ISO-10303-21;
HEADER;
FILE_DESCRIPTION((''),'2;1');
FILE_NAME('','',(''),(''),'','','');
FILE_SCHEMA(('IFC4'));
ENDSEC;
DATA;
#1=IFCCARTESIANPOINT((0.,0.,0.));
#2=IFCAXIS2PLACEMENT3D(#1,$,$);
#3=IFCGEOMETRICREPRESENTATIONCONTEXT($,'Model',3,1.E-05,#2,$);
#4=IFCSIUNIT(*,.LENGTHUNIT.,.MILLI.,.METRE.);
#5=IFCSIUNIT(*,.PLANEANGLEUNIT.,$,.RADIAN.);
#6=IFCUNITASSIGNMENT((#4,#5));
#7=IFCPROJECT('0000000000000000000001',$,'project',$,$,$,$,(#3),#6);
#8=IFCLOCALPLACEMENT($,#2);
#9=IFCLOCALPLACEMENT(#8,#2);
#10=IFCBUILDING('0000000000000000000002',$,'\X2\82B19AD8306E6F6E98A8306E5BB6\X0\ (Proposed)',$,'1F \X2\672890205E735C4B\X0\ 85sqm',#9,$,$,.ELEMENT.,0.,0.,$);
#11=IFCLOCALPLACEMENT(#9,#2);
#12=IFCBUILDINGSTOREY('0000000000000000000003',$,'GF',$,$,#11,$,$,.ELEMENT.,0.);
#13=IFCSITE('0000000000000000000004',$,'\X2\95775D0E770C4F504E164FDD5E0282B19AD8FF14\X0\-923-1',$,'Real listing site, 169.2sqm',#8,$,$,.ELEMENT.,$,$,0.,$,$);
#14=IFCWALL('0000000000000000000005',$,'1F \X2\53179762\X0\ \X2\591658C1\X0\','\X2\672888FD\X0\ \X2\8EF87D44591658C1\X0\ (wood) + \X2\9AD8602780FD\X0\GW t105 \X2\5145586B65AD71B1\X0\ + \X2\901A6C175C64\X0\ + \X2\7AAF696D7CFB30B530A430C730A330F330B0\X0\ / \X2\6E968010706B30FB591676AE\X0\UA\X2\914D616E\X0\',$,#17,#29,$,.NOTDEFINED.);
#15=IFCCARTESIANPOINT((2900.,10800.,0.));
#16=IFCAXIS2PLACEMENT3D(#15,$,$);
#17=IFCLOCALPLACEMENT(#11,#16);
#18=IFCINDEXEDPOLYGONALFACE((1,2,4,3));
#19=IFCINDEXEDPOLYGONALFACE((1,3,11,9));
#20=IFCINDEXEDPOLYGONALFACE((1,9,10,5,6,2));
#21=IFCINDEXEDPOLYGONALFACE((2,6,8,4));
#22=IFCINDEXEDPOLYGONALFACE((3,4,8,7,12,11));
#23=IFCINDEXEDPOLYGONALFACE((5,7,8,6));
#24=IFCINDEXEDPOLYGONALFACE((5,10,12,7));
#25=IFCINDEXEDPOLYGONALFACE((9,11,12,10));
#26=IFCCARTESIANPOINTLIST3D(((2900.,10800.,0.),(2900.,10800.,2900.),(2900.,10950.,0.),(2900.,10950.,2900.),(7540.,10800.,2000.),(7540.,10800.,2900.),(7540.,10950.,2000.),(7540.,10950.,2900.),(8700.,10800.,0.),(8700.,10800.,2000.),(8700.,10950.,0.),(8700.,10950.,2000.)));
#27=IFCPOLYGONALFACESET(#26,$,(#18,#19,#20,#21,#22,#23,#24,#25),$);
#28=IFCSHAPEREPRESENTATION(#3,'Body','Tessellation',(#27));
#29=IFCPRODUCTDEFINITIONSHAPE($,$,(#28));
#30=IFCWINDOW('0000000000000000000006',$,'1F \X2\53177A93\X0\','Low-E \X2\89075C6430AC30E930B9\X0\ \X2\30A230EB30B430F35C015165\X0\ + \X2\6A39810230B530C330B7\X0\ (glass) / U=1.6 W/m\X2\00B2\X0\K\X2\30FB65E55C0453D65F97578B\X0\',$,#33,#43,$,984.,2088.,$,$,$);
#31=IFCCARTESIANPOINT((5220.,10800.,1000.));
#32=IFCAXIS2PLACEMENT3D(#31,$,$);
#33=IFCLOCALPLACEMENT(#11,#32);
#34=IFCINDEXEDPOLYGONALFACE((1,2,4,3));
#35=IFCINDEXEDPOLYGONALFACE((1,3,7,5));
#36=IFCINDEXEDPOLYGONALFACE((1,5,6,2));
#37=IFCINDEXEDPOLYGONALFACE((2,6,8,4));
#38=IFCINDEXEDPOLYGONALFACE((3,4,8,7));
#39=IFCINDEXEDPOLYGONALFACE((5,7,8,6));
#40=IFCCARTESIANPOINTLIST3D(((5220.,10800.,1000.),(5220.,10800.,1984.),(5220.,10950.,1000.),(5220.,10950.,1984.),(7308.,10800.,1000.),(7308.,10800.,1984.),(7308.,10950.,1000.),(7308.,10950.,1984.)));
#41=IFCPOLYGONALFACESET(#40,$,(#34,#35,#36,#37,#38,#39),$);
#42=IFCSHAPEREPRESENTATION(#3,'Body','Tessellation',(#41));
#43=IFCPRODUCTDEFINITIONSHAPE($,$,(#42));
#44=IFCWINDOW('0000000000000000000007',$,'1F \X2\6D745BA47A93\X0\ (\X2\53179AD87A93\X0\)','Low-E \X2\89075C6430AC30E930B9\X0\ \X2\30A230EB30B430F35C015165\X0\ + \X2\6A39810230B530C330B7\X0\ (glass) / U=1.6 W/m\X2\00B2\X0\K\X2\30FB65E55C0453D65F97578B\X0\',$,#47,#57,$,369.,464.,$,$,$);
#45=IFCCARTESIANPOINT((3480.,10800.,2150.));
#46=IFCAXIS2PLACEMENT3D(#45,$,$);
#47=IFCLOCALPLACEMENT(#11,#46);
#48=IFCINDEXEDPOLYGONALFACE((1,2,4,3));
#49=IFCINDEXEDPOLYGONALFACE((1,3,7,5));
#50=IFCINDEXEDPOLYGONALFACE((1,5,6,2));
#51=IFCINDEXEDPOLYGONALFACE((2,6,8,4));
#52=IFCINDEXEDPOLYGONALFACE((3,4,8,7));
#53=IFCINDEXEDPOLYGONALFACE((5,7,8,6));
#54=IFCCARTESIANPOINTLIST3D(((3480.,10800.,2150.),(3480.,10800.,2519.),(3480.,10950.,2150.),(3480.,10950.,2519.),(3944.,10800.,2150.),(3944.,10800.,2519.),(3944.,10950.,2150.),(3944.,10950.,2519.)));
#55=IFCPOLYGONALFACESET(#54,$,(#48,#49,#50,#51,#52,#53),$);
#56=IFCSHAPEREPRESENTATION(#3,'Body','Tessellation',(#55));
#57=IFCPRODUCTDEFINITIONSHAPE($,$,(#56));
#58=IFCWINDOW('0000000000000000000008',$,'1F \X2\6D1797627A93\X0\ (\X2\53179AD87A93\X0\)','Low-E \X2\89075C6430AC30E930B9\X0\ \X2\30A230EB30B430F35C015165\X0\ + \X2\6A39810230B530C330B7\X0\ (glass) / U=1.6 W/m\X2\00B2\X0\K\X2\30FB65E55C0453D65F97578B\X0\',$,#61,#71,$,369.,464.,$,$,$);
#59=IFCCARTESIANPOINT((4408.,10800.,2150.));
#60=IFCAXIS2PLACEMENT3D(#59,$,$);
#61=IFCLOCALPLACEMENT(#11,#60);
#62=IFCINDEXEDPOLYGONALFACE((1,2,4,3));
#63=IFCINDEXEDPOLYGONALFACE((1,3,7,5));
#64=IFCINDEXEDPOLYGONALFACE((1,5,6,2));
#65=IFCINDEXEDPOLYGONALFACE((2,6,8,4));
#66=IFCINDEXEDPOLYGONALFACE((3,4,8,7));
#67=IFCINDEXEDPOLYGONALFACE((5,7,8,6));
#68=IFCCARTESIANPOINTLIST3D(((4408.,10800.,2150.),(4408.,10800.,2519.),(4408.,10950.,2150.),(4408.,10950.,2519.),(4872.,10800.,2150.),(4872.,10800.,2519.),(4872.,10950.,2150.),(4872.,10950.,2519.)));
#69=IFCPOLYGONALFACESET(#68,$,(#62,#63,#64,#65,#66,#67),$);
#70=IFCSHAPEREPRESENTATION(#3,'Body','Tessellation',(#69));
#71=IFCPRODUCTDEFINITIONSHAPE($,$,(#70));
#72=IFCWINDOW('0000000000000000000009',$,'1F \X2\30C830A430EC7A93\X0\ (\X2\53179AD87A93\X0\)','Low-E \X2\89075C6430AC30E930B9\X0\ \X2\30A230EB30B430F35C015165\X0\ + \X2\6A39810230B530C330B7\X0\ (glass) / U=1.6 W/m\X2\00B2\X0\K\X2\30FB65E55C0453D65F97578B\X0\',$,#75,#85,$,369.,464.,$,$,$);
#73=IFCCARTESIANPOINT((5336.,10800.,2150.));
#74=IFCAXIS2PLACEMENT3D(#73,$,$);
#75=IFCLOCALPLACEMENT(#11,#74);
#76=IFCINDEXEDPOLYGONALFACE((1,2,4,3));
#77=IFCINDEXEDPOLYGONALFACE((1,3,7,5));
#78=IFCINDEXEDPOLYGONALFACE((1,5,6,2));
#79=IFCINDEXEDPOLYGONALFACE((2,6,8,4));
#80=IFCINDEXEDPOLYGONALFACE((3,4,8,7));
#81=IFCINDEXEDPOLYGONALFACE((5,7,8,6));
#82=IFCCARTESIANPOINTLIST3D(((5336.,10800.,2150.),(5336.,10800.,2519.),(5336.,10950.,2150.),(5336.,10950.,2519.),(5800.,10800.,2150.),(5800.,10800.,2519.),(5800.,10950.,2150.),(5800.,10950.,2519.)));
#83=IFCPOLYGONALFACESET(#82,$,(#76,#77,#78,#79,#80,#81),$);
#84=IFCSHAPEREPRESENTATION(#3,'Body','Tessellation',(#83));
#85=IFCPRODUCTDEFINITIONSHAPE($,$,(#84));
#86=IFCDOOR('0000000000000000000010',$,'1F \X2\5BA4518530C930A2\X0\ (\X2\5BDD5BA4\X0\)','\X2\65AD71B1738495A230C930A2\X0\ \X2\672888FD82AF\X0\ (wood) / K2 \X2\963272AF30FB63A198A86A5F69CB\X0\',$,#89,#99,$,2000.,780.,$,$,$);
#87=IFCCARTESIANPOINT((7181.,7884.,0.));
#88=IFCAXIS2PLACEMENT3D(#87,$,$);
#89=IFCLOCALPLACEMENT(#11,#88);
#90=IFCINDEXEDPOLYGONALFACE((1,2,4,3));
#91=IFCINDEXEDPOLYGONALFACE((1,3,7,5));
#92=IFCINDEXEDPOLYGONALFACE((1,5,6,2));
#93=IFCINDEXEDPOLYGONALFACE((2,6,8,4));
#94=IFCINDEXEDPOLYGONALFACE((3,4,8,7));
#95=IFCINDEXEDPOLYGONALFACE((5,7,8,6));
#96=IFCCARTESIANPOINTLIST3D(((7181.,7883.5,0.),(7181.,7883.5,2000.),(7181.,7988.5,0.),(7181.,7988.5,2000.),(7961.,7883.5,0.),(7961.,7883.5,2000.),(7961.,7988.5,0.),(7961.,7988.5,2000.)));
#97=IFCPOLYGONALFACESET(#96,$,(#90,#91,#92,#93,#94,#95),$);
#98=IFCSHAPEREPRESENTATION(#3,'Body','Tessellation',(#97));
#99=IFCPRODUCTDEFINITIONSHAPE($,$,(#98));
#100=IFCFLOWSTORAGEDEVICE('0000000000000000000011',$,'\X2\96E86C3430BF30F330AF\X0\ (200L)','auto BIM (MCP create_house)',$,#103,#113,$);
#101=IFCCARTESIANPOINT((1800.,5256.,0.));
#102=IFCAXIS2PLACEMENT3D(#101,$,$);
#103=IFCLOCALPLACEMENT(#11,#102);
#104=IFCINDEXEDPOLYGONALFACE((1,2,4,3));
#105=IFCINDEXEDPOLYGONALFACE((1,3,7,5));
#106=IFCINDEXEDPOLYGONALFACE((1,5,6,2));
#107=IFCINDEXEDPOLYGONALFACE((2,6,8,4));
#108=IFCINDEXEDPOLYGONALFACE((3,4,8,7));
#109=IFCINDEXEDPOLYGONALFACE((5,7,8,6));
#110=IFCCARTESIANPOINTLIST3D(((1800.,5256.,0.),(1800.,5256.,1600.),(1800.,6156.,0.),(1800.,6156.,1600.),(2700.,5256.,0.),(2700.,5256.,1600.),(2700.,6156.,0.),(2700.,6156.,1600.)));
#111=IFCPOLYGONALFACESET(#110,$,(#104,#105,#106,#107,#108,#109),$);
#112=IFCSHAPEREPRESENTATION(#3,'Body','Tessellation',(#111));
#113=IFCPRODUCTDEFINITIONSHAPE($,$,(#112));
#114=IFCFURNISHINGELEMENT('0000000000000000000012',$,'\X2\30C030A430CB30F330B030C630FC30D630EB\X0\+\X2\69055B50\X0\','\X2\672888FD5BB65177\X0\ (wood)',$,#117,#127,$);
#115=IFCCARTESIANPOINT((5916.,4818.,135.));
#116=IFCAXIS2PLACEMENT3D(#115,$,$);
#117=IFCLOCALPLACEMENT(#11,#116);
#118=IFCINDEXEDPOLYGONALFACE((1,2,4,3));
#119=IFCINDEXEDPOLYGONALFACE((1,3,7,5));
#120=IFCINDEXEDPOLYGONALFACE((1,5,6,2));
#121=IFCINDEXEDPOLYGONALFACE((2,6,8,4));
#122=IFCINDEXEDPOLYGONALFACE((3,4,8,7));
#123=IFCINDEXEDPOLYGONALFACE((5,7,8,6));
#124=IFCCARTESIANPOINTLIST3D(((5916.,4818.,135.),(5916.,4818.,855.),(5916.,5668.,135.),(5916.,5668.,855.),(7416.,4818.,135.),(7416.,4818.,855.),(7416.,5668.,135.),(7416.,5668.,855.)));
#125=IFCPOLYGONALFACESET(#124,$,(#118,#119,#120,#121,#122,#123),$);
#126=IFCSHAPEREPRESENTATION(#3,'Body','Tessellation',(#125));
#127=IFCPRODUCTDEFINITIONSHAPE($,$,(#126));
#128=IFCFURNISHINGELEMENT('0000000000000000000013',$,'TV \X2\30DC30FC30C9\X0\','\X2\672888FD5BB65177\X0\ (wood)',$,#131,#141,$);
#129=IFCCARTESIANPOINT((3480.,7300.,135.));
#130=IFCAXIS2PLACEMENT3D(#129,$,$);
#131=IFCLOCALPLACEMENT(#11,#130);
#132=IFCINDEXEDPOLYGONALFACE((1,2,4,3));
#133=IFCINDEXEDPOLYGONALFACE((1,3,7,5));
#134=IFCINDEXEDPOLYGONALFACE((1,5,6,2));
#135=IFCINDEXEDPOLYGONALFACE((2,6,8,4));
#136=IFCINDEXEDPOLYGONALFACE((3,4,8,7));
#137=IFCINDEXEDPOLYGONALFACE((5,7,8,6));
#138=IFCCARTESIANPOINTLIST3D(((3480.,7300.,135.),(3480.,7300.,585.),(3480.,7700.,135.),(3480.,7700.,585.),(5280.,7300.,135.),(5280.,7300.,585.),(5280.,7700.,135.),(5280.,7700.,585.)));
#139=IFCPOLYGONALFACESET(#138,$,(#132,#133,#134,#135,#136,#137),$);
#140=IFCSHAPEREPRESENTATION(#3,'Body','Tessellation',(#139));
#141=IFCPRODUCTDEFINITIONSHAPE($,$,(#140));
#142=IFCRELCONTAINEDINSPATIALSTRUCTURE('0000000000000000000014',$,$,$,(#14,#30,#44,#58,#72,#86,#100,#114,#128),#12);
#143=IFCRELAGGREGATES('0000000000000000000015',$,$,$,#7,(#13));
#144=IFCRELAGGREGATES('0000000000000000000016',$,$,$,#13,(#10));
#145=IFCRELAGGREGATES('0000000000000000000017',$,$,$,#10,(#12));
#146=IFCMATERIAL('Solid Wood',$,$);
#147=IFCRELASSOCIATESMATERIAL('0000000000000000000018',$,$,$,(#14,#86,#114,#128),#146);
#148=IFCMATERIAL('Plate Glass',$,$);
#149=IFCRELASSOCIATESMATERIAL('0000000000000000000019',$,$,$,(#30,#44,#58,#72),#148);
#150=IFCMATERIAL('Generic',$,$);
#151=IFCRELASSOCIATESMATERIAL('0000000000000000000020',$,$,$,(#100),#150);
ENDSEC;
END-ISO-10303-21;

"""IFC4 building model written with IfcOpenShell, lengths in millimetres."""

from ifc_helpers import new_model, si_unit, frame, frame_2d, origin, place, context, project, spatial, rectangle, extrude, material, element, fill, save


model = new_model("IFC4")

# Units and contexts
model_context = context("Model", 3, precision=1e-05, world=origin())
ifc_project = project(units=[si_unit("LENGTHUNIT", "METRE", prefix="MILLI"), si_unit("PLANEANGLEUNIT", "RADIAN")], contexts=[model_context])

# Site, building, storey
site_placement = place(None, origin())
site = spatial("IfcSite", under=ifc_project, at=site_placement, Name="長崎県佐世保市花高４-923-1", ObjectType="Real listing site, 169.2sqm", CompositionType="ELEMENT", RefElevation=0.0)
building_placement = place(site_placement, origin())
building = spatial("IfcBuilding", under=site, at=building_placement, Name="花高の潮風の家 (Proposed)", ObjectType="1F 木造平屋 85sqm", CompositionType="ELEMENT", ElevationOfRefHeight=0.0, ElevationOfTerrain=0.0)
storey_placement = place(building_placement, origin())
storey = spatial("IfcBuildingStorey", under=building, at=storey_placement, Name="GF", CompositionType="ELEMENT", Elevation=0.0)

# Wall, openings, windows
ifc_material_1 = material(Name="Solid Wood")
wall_1_placement = place(storey_placement, frame((2900.0, 10800.0, 0.0)))
wall_1 = element("IfcWall", 1, at=wall_1_placement, inside=storey, material=ifc_material_1, Name="1F 北面 外壁", Description="木製 軸組外壁 (wood) + 高性能GW t105 充填断熱 + 通気層 + 窯業系サイディング / 準耐火・外皮UA配慮", PredefinedType="NOTDEFINED", context=model_context, shape_type="SweptSolid", body=[
    extrude(rectangle(XDim=5800.0, YDim=150.0, at=frame_2d((2900.0, 75.0))), frame((2900.0, 10800.0, 0.0)), (0.0, 0.0, 1.0), 2900.0),
])
opening_1_placement = place(storey_placement, frame((5220.0, 10800.0, 1000.0)))
opening_1 = element("IfcOpeningElement", 2, at=opening_1_placement, cuts=wall_1, PredefinedType="NOTDEFINED", context=model_context, shape_type="SweptSolid", body=[
    extrude(rectangle(XDim=2088.0, YDim=150.0, at=frame_2d((1044.0, 75.0))), frame((5220.0, 10800.0, 1000.0)), (0.0, 0.0, 1.0), 984.0),
])
opening_2_placement = place(storey_placement, frame((3480.0, 10800.0, 2150.0)))
opening_2 = element("IfcOpeningElement", 3, at=opening_2_placement, cuts=wall_1, PredefinedType="NOTDEFINED", context=model_context, shape_type="SweptSolid", body=[
    extrude(rectangle(XDim=464.0, YDim=150.0, at=frame_2d((232.0, 75.0))), frame((3480.0, 10800.0, 2150.0)), (0.0, 0.0, 1.0), 369.0),
])
opening_3_placement = place(storey_placement, frame((4408.0, 10800.0, 2150.0)))
opening_3 = element("IfcOpeningElement", 4, at=opening_3_placement, cuts=wall_1, PredefinedType="NOTDEFINED", context=model_context, shape_type="SweptSolid", body=[
    extrude(rectangle(XDim=464.0, YDim=150.0, at=frame_2d((232.0, 75.0))), frame((4408.0, 10800.0, 2150.0)), (0.0, 0.0, 1.0), 369.0),
])
opening_4_placement = place(storey_placement, frame((5336.0, 10800.0, 2150.0)))
opening_4 = element("IfcOpeningElement", 5, at=opening_4_placement, cuts=wall_1, PredefinedType="NOTDEFINED", context=model_context, shape_type="SweptSolid", body=[
    extrude(rectangle(XDim=464.0, YDim=150.0, at=frame_2d((232.0, 75.0))), frame((5336.0, 10800.0, 2150.0)), (0.0, 0.0, 1.0), 369.0),
])
ifc_material_2 = material(Name="Plate Glass")
window_1_placement = place(storey_placement, frame((5220.0, 10800.0, 1000.0)))
window_1 = element("IfcWindow", 6, at=window_1_placement, inside=storey, material=ifc_material_2, Name="1F 北窓", Description="Low-E 複層ガラス アルゴン封入 + 樹脂サッシ (glass) / U=1.6 W/m²K・日射取得型", OverallHeight=984.0, OverallWidth=2088.0, context=model_context, shape_type="SweptSolid", body=[
    extrude(rectangle(XDim=2088.0, YDim=150.0, at=frame_2d((1044.0, 75.0))), frame((5220.0, 10800.0, 1000.0)), (0.0, 0.0, 1.0), 984.0),
])
fill(opening_1, window_1)
window_2_placement = place(storey_placement, frame((3480.0, 10800.0, 2150.0)))
window_2 = element("IfcWindow", 7, at=window_2_placement, inside=storey, material=ifc_material_2, Name="1F 浴室窓 (北高窓)", Description="Low-E 複層ガラス アルゴン封入 + 樹脂サッシ (glass) / U=1.6 W/m²K・日射取得型", OverallHeight=369.0, OverallWidth=464.0, context=model_context, shape_type="SweptSolid", body=[
    extrude(rectangle(XDim=464.0, YDim=150.0, at=frame_2d((232.0, 75.0))), frame((3480.0, 10800.0, 2150.0)), (0.0, 0.0, 1.0), 369.0),
])
fill(opening_2, window_2)
window_3_placement = place(storey_placement, frame((4408.0, 10800.0, 2150.0)))
window_3 = element("IfcWindow", 8, at=window_3_placement, inside=storey, material=ifc_material_2, Name="1F 洗面窓 (北高窓)", Description="Low-E 複層ガラス アルゴン封入 + 樹脂サッシ (glass) / U=1.6 W/m²K・日射取得型", OverallHeight=369.0, OverallWidth=464.0, context=model_context, shape_type="SweptSolid", body=[
    extrude(rectangle(XDim=464.0, YDim=150.0, at=frame_2d((232.0, 75.0))), frame((4408.0, 10800.0, 2150.0)), (0.0, 0.0, 1.0), 369.0),
])
fill(opening_3, window_3)
window_4_placement = place(storey_placement, frame((5336.0, 10800.0, 2150.0)))
window_4 = element("IfcWindow", 9, at=window_4_placement, inside=storey, material=ifc_material_2, Name="1F トイレ窓 (北高窓)", Description="Low-E 複層ガラス アルゴン封入 + 樹脂サッシ (glass) / U=1.6 W/m²K・日射取得型", OverallHeight=369.0, OverallWidth=464.0, context=model_context, shape_type="SweptSolid", body=[
    extrude(rectangle(XDim=464.0, YDim=150.0, at=frame_2d((232.0, 75.0))), frame((5336.0, 10800.0, 2150.0)), (0.0, 0.0, 1.0), 369.0),
])
fill(opening_4, window_4)

# Door
door_1_placement = place(storey_placement, frame((7181.0, 7884.0, 0.0)))
element("IfcDoor", 10, at=door_1_placement, inside=storey, material=ifc_material_1, Name="1F 室内ドア (寝室)", Description="断熱玄関ドア 木製芯 (wood) / K2 防犯・採風機構", OverallHeight=2000.0, OverallWidth=780.0, context=model_context, shape_type="SweptSolid", body=[
    extrude(rectangle(XDim=780.0, YDim=105.0, at=frame_2d((390.0, 52.0))), frame((7181.0, 7884.0, 0.0)), (0.0, 0.0, 1.0), 2000.0),
])

# Flow storage device
ifc_material_3 = material(Name="Generic")
flow_storage_device_placement = place(storey_placement, frame((1800.0, 5256.0, 0.0)))
element("IfcFlowStorageDevice", 11, at=flow_storage_device_placement, inside=storey, material=ifc_material_3, Name="雨水タンク (200L)", Description="auto BIM (MCP create_house)", context=model_context, shape_type="SweptSolid", body=[
    extrude(rectangle(XDim=900.0, YDim=900.0, at=frame_2d((450.0, 450.0))), frame((1800.0, 5256.0, 0.0)), (0.0, 0.0, 1.0), 1600.0),
])

# Furnishing elements
furnishing_1_placement = place(storey_placement, frame((5916.0, 4818.0, 135.0)))
element("IfcFurnishingElement", 12, at=furnishing_1_placement, inside=storey, material=ifc_material_1, Name="ダイニングテーブル+椅子", Description="木製家具 (wood)", context=model_context, shape_type="SweptSolid", body=[
    extrude(rectangle(XDim=1500.0, YDim=850.0, at=frame_2d((750.0, 425.0))), frame((5916.0, 4818.0, 135.0)), (0.0, 0.0, 1.0), 720.0),
])
furnishing_2_placement = place(storey_placement, frame((3480.0, 7300.0, 135.0)))
element("IfcFurnishingElement", 13, at=furnishing_2_placement, inside=storey, material=ifc_material_1, Name="TV ボード", Description="木製家具 (wood)", context=model_context, shape_type="SweptSolid", body=[
    extrude(rectangle(XDim=1800.0, YDim=400.0, at=frame_2d((900.0, 200.0))), frame((3480.0, 7300.0, 135.0)), (0.0, 0.0, 1.0), 450.0),
])

save(model, "model.ifc")
